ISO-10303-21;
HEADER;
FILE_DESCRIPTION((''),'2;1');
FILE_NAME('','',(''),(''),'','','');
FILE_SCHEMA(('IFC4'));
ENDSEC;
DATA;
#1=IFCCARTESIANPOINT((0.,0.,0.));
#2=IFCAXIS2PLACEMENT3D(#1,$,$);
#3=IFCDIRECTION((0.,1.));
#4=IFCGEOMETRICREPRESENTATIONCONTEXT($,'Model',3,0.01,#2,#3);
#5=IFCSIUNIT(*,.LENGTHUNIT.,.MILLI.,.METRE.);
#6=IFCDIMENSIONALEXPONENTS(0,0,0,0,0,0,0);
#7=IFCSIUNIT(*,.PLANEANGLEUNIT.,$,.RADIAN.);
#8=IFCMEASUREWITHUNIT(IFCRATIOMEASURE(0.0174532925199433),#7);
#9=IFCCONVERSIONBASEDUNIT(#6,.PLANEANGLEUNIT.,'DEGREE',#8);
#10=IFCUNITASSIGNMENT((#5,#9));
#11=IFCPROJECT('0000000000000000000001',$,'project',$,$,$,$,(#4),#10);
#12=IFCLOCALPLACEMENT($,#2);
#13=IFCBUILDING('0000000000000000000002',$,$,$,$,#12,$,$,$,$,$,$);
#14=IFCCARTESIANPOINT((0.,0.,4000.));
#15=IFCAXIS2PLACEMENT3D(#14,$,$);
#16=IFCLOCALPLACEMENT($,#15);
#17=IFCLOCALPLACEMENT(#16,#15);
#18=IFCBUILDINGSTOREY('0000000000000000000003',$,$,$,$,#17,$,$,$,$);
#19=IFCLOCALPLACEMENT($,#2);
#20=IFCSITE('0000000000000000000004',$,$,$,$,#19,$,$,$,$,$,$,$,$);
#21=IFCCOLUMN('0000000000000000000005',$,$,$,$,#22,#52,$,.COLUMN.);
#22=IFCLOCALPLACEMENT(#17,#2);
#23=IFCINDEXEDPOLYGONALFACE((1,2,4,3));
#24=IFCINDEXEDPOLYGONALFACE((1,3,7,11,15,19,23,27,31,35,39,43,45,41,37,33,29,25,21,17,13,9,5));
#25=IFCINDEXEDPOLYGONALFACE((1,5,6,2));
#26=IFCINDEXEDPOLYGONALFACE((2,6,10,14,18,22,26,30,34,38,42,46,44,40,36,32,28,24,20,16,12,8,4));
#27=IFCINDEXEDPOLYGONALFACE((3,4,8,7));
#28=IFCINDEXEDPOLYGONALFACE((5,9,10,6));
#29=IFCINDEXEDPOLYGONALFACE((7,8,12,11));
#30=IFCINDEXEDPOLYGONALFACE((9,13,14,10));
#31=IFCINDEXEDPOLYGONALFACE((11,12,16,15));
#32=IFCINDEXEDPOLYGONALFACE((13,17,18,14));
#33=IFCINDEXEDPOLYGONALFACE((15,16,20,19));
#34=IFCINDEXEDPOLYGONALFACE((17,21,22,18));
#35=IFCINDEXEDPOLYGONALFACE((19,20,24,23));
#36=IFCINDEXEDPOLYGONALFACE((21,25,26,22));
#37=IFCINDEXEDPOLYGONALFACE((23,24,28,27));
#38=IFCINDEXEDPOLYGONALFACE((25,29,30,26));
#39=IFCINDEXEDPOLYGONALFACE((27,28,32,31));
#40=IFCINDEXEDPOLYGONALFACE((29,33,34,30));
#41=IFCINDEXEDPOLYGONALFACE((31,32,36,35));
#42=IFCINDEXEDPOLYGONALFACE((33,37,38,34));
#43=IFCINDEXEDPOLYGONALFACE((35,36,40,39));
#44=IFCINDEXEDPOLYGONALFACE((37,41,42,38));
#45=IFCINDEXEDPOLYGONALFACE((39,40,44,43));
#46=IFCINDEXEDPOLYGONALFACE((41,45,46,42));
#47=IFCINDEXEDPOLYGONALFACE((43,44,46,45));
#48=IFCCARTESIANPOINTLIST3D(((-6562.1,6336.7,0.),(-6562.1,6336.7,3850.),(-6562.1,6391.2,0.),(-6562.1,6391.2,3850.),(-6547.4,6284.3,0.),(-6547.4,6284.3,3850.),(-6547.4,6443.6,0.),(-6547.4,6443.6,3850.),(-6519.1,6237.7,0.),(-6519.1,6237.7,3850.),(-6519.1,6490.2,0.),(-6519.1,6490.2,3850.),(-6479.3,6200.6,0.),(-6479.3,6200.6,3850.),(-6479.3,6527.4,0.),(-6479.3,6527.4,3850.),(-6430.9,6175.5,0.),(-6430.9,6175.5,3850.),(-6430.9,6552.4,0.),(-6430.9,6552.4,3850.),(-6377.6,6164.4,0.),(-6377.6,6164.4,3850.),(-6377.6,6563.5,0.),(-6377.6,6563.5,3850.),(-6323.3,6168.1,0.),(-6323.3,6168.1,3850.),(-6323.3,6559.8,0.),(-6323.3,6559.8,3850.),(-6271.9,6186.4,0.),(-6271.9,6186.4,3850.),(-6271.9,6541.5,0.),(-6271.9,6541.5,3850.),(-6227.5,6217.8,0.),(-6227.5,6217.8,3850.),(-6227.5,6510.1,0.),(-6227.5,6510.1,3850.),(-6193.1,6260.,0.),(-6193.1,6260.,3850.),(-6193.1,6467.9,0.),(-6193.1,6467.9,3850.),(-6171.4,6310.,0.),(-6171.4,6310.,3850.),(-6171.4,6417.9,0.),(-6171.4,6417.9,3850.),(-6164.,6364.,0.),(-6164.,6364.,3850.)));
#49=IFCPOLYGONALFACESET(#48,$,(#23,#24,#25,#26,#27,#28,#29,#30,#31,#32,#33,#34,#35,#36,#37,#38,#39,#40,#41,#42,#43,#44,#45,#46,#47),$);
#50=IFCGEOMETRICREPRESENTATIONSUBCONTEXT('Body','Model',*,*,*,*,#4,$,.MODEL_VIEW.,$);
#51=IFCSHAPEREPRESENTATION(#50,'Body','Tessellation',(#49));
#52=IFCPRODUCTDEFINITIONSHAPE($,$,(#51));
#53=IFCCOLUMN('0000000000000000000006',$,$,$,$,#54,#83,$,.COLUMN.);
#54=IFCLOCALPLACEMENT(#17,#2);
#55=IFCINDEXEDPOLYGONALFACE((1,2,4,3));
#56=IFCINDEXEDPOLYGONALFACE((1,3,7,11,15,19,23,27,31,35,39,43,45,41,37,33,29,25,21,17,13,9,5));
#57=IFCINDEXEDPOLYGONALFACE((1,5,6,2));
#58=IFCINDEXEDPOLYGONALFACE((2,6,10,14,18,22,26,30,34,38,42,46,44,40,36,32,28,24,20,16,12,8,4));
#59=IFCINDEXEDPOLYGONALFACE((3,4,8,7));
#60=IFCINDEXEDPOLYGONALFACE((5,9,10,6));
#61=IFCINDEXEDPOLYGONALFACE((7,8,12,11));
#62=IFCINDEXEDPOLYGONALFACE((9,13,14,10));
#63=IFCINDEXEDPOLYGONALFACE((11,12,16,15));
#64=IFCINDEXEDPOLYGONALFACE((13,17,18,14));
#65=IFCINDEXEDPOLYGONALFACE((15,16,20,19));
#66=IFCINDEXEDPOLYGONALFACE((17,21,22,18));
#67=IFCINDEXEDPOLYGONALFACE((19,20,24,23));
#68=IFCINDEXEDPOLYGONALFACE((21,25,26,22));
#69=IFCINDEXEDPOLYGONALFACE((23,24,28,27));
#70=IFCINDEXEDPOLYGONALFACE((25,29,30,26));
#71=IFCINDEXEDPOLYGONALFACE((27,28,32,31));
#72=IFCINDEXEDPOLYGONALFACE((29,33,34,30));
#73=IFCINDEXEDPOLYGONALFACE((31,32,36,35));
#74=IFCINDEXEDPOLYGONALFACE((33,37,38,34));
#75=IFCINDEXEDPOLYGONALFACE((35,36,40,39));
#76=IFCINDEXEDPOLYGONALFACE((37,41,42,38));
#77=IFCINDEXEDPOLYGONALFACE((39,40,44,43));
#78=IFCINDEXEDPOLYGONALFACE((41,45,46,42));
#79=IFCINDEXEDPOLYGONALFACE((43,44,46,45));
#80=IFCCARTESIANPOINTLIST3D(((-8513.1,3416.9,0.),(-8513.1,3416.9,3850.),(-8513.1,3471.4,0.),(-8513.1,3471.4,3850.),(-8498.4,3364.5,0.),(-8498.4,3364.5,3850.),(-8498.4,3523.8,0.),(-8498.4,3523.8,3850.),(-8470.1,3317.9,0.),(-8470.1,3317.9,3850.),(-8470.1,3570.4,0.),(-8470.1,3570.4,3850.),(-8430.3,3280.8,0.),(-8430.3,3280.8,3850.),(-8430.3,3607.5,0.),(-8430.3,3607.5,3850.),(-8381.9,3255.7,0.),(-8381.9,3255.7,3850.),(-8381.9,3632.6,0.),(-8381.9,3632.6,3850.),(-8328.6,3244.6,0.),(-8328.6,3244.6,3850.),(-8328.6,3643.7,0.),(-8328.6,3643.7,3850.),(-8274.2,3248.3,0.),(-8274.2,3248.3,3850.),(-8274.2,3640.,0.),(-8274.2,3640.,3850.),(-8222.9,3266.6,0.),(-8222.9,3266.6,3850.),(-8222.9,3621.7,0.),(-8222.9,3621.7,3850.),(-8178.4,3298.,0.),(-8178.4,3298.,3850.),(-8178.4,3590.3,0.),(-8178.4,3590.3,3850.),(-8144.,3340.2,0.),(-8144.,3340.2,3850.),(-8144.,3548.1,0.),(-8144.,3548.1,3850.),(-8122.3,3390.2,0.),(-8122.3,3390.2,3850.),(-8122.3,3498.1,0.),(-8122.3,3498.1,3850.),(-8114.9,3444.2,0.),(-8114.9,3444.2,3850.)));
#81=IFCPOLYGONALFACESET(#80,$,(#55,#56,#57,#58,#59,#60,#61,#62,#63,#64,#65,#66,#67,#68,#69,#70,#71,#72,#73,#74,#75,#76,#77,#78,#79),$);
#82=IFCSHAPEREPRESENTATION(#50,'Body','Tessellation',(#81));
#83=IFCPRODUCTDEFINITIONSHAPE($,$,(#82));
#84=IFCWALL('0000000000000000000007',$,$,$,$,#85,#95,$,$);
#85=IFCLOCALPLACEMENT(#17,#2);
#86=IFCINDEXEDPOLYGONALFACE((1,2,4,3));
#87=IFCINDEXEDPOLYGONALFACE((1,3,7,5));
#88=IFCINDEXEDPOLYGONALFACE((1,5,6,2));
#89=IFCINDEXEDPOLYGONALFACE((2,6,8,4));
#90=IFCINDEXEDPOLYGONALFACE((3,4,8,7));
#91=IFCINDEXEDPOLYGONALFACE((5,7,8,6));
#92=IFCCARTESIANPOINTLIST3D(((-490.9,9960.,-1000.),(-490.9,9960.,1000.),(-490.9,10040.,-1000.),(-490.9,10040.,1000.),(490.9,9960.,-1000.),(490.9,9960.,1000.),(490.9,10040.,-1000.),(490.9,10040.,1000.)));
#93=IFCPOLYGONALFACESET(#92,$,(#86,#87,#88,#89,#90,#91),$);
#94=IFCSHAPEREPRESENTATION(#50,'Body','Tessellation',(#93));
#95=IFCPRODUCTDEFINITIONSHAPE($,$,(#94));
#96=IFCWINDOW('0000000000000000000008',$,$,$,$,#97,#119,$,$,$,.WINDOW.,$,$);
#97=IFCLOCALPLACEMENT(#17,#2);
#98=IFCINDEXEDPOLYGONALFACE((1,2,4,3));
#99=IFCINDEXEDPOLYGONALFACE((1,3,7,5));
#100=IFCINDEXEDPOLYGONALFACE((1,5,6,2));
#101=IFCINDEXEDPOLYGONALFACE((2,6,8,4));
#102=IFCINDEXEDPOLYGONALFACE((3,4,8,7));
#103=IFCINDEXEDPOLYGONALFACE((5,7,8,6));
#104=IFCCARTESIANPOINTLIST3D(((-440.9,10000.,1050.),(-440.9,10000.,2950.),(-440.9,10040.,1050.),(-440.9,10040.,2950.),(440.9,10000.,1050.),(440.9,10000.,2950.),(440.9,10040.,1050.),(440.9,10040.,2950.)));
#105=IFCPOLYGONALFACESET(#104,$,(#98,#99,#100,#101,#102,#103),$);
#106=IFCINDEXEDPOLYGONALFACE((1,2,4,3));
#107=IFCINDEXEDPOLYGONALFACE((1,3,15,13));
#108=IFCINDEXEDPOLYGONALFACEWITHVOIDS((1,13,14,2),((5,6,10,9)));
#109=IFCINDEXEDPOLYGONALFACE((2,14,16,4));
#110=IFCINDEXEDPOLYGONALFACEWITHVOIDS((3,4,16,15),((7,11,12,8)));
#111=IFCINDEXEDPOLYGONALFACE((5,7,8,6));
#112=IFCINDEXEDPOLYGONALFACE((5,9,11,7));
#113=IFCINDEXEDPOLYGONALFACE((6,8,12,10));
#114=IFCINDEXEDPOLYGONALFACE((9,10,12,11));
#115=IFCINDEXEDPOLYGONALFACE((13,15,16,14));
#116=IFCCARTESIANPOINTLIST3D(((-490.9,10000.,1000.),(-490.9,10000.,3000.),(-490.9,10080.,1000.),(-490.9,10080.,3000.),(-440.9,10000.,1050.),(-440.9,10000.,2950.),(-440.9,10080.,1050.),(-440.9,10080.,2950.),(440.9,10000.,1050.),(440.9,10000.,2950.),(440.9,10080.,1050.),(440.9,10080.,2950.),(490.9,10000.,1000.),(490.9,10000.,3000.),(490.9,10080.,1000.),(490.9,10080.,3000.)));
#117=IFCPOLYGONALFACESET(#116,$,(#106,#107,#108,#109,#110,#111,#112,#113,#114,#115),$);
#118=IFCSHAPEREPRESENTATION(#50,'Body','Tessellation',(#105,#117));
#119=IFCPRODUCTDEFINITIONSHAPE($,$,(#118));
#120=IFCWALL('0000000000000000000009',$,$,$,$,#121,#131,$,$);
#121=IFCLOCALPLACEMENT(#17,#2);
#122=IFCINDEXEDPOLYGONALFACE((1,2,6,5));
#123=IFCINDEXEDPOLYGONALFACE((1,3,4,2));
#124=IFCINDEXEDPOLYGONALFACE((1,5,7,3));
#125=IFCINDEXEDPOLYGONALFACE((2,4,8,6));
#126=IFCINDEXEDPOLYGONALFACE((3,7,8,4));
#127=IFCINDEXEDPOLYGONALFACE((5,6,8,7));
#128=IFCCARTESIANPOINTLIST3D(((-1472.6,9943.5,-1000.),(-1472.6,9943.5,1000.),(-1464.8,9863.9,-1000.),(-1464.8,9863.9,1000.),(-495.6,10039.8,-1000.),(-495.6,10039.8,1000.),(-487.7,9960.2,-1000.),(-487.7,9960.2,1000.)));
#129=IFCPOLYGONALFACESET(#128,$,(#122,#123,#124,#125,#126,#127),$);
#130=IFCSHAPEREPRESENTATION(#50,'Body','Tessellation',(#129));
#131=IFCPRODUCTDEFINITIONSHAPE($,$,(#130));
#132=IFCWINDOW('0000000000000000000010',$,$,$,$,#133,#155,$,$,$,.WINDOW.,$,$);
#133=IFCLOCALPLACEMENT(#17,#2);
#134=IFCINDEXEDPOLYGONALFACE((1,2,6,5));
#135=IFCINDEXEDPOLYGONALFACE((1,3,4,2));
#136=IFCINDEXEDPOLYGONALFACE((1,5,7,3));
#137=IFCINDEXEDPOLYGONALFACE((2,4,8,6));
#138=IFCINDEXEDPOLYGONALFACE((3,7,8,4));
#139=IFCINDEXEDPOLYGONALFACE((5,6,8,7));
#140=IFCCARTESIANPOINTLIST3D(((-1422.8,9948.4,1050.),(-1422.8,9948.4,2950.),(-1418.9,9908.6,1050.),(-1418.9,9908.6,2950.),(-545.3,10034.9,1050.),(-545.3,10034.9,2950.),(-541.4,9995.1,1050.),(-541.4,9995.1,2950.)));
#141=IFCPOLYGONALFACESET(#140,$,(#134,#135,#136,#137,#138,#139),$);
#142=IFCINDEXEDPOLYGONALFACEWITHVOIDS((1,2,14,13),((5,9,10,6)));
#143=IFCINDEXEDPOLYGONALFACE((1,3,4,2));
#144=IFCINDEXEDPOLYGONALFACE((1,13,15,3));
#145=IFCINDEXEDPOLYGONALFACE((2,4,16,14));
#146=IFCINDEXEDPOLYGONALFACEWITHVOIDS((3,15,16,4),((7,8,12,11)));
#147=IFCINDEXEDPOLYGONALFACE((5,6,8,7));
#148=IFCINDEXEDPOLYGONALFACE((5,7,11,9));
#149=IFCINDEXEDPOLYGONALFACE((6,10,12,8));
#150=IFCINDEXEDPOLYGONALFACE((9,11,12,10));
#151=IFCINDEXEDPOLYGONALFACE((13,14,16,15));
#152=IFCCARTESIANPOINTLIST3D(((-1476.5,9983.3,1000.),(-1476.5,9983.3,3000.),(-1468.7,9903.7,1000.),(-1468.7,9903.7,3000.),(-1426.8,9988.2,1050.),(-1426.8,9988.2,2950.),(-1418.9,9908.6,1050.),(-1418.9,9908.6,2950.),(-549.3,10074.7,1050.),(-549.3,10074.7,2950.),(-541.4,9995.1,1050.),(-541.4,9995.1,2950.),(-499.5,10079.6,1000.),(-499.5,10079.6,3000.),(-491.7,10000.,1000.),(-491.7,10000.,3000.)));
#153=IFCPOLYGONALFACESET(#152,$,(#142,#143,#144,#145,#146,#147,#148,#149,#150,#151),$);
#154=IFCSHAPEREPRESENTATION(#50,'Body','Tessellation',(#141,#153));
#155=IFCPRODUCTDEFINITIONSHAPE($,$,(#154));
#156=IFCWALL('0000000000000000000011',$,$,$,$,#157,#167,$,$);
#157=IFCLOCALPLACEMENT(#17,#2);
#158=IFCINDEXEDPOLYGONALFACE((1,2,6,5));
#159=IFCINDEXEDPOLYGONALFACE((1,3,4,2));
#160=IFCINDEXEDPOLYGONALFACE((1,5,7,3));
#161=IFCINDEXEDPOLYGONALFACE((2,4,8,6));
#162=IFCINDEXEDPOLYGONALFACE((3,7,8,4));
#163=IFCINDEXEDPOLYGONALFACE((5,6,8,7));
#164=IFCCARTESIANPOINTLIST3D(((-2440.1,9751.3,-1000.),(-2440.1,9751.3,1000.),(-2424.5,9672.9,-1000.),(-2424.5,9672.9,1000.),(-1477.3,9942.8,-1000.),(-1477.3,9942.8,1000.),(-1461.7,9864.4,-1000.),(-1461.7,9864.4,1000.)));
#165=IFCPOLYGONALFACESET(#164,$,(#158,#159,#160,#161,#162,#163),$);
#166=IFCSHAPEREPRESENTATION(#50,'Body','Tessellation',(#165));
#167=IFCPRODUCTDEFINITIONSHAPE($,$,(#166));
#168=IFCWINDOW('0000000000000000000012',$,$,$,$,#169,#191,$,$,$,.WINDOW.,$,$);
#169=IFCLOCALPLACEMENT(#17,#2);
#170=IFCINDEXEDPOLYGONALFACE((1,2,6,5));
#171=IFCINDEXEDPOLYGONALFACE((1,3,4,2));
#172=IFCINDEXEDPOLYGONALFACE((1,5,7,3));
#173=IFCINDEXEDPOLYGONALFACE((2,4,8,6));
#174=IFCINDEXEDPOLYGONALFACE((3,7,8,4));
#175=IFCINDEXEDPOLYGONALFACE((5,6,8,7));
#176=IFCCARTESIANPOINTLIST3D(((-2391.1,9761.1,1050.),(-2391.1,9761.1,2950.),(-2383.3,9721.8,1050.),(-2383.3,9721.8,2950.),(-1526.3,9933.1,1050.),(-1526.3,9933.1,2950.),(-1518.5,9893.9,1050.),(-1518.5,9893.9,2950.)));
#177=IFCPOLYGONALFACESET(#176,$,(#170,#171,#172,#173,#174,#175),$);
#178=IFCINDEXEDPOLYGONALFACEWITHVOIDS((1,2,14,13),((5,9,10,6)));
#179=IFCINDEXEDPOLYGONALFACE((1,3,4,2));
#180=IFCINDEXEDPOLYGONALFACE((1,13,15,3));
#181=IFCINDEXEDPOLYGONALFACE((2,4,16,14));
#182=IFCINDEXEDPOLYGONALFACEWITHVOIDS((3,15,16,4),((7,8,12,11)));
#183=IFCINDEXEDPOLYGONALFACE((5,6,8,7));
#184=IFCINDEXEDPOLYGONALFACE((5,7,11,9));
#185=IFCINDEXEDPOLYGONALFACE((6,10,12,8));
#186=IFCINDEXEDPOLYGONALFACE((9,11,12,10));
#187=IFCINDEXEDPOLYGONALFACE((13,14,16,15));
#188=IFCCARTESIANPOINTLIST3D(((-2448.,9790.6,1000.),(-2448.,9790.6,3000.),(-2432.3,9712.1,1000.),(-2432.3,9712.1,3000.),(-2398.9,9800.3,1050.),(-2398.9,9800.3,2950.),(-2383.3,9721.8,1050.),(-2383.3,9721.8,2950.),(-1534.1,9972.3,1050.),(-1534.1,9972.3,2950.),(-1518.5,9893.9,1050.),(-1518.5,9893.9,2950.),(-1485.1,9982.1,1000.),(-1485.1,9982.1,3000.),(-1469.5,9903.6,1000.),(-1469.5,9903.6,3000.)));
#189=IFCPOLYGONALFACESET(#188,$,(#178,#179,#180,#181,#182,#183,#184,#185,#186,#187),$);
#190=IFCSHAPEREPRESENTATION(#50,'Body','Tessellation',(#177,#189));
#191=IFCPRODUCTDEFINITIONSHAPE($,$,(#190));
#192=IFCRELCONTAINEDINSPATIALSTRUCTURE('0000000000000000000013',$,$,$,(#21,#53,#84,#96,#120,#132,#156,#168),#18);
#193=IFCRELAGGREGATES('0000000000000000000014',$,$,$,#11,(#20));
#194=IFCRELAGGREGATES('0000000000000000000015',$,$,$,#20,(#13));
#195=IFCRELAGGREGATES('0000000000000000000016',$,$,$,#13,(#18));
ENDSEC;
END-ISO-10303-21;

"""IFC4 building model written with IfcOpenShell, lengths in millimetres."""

from ifc_helpers import new_model, entity, si_unit, converted_unit, direction, frame, origin, origin_2d, place, context, subcontext, project, spatial, rectangle, circle, extrude, element, save


model = new_model("IFC4")

# Units and contexts
model_context = context("Model", 3, precision=0.01, world=origin(), true_north=direction((0.0, 1.0)))
body_context = subcontext(model_context, "Body", "Model", "MODEL_VIEW")
ifc_project = project(units=[si_unit("LENGTHUNIT", "METRE", prefix="MILLI"), converted_unit("PLANEANGLEUNIT", "DEGREE", entity("IfcRatioMeasure", 0.0174532925199433), si_unit("PLANEANGLEUNIT", "RADIAN"), dimensions=[0, 0, 0, 0, 0, 0, 0])], contexts=[model_context])

# Site, building, storey
site_placement = place(None, origin())
site = spatial("IfcSite", under=ifc_project, at=site_placement)
building_placement = place(None, origin())
building = spatial("IfcBuilding", under=site, at=building_placement)
placement = place(None, frame((0.0, 0.0, 4000.0)))
storey_placement = place(placement, frame((0.0, 0.0, 4000.0)))
storey = spatial("IfcBuildingStorey", under=building, at=storey_placement)

# Columns
for number, where in (
    (1, (-6364.0, 6364.0, 0.0)),
    (2, (-8314.9, 3444.2, 0.0)),
):
    element("IfcColumn", number, at=place(storey_placement, frame(where)), inside=storey, PredefinedType="COLUMN", context=body_context, shape_type="SweptSolid", body=[
        extrude(circle(Radius=200.0, at=origin_2d()), origin(), (0.0, 0.0, 1.0), 3850.0),
    ])

# Wall
wall_1_placement = place(storey_placement, frame((0.0, 10000.0, -1000.0), z_axis=(0.0, 0.0, 1.0), x_axis=(-10000.0, -0.000437, 0.0)))
element("IfcWall", 3, at=wall_1_placement, inside=storey, context=body_context, shape_type="SweptSolid", body=[
    extrude(rectangle(XDim=981.7, YDim=80.0, at=origin_2d()), origin(), (0.0, 0.0, 1.0), 2000.0),
])

# Window
cartesian_point_1 = entity("IfcCartesianPoint", [-440.9, -950.0])
shared_polyline = entity("IfcPolyline", [cartesian_point_1, entity("IfcCartesianPoint", [-440.9, 950.0]), entity("IfcCartesianPoint", [-440.9, 950.0]), entity("IfcCartesianPoint", [440.9, 950.0]), entity("IfcCartesianPoint", [440.9, 950.0]), entity("IfcCartesianPoint", [440.9, -950.0]), entity("IfcCartesianPoint", [440.9, -950.0]), entity("IfcCartesianPoint", [-440.9, -950.0]), cartesian_point_1])
window_1_placement = place(storey_placement, frame((0.0, 10000.0, 2000.0), z_axis=(0.0, 0.0, 1.0), x_axis=(-10000.0, -0.000437, 0.0)))
cartesian_point_2 = entity("IfcCartesianPoint", [-490.9, -1000.0])
element("IfcWindow", 4, at=window_1_placement, inside=storey, PredefinedType="WINDOW", context=body_context, shape_type="SweptSolid", body=[
    entity("IfcExtrudedAreaSolid", entity("IfcArbitraryClosedProfileDef", "AREA", None, shared_polyline), entity("IfcAxis2Placement3D", entity("IfcCartesianPoint", [0.0, 0.0, 0.0]), entity("IfcDirection", [0.0, -1.0, 0.0]), entity("IfcDirection", [1.0, 0.0, 0.0])), entity("IfcDirection", [0.0, 0.0, 1.0]), 40.0),
    entity("IfcExtrudedAreaSolid", entity("IfcArbitraryProfileDefWithVoids", "AREA", None, entity("IfcPolyline", [cartesian_point_2, entity("IfcCartesianPoint", [-490.9, 1000.0]), entity("IfcCartesianPoint", [-490.9, 1000.0]), entity("IfcCartesianPoint", [490.9, 1000.0]), entity("IfcCartesianPoint", [490.9, 1000.0]), entity("IfcCartesianPoint", [490.9, -1000.0]), entity("IfcCartesianPoint", [490.9, -1000.0]), entity("IfcCartesianPoint", [-490.9, -1000.0]), cartesian_point_2]), [shared_polyline]), entity("IfcAxis2Placement3D", entity("IfcCartesianPoint", [0.0, 0.0, 0.0]), entity("IfcDirection", [0.0, -1.0, 0.0]), entity("IfcDirection", [1.0, 0.0, 0.0])), entity("IfcDirection", [0.0, 0.0, 1.0]), 80.0),
])

# Wall
wall_2_placement = place(storey_placement, frame((-980.2, 9951.8, -1000.0), z_axis=(0.0, 0.0, 1.0), x_axis=(-9951.847302, -980.17105, 0.0)))
element("IfcWall", 5, at=wall_2_placement, inside=storey, context=body_context, shape_type="SweptSolid", body=[
    extrude(rectangle(XDim=981.7, YDim=80.0, at=origin_2d()), origin(), (0.0, 0.0, 1.0), 2000.0),
])

# Window
window_2_placement = place(storey_placement, frame((-980.2, 9951.8, 2000.0), z_axis=(0.0, 0.0, 1.0), x_axis=(-9951.847302, -980.17105, 0.0)))
cartesian_point_3 = entity("IfcCartesianPoint", [-490.9, -1000.0])
element("IfcWindow", 6, at=window_2_placement, inside=storey, PredefinedType="WINDOW", context=body_context, shape_type="SweptSolid", body=[
    entity("IfcExtrudedAreaSolid", entity("IfcArbitraryClosedProfileDef", "AREA", None, shared_polyline), entity("IfcAxis2Placement3D", entity("IfcCartesianPoint", [0.0, 0.0, 0.0]), entity("IfcDirection", [0.0, -1.0, 0.0]), entity("IfcDirection", [1.0, 0.0, 0.0])), entity("IfcDirection", [0.0, 0.0, 1.0]), 40.0),
    entity("IfcExtrudedAreaSolid", entity("IfcArbitraryProfileDefWithVoids", "AREA", None, entity("IfcPolyline", [cartesian_point_3, entity("IfcCartesianPoint", [-490.9, 1000.0]), entity("IfcCartesianPoint", [-490.9, 1000.0]), entity("IfcCartesianPoint", [490.9, 1000.0]), entity("IfcCartesianPoint", [490.9, 1000.0]), entity("IfcCartesianPoint", [490.9, -1000.0]), entity("IfcCartesianPoint", [490.9, -1000.0]), entity("IfcCartesianPoint", [-490.9, -1000.0]), cartesian_point_3]), [shared_polyline]), entity("IfcAxis2Placement3D", entity("IfcCartesianPoint", [0.0, 0.0, 0.0]), entity("IfcDirection", [0.0, -1.0, 0.0]), entity("IfcDirection", [1.0, 0.0, 0.0])), entity("IfcDirection", [0.0, 0.0, 1.0]), 80.0),
])

# Wall
wall_3_placement = place(storey_placement, frame((-1950.9, 9807.9, -1000.0), z_axis=(0.0, 0.0, 1.0), x_axis=(-9807.852795, -1950.903264, 0.0)))
element("IfcWall", 7, at=wall_3_placement, inside=storey, context=body_context, shape_type="SweptSolid", body=[
    extrude(rectangle(XDim=981.7, YDim=80.0, at=origin_2d()), origin(), (0.0, 0.0, 1.0), 2000.0),
])

# Window
window_3_placement = place(storey_placement, frame((-1950.9, 9807.9, 2000.0), z_axis=(0.0, 0.0, 1.0), x_axis=(-9807.852795, -1950.903264, 0.0)))
cartesian_point_4 = entity("IfcCartesianPoint", [-490.9, -1000.0])
element("IfcWindow", 8, at=window_3_placement, inside=storey, PredefinedType="WINDOW", context=body_context, shape_type="SweptSolid", body=[
    entity("IfcExtrudedAreaSolid", entity("IfcArbitraryClosedProfileDef", "AREA", None, shared_polyline), entity("IfcAxis2Placement3D", entity("IfcCartesianPoint", [0.0, 0.0, 0.0]), entity("IfcDirection", [0.0, -1.0, 0.0]), entity("IfcDirection", [1.0, 0.0, 0.0])), entity("IfcDirection", [0.0, 0.0, 1.0]), 40.0),
    entity("IfcExtrudedAreaSolid", entity("IfcArbitraryProfileDefWithVoids", "AREA", None, entity("IfcPolyline", [cartesian_point_4, entity("IfcCartesianPoint", [-490.9, 1000.0]), entity("IfcCartesianPoint", [-490.9, 1000.0]), entity("IfcCartesianPoint", [490.9, 1000.0]), entity("IfcCartesianPoint", [490.9, 1000.0]), entity("IfcCartesianPoint", [490.9, -1000.0]), entity("IfcCartesianPoint", [490.9, -1000.0]), entity("IfcCartesianPoint", [-490.9, -1000.0]), cartesian_point_4]), [shared_polyline]), entity("IfcAxis2Placement3D", entity("IfcCartesianPoint", [0.0, 0.0, 0.0]), entity("IfcDirection", [0.0, -1.0, 0.0]), entity("IfcDirection", [1.0, 0.0, 0.0])), entity("IfcDirection", [0.0, 0.0, 1.0]), 80.0),
])

save(model, "model.ifc")
